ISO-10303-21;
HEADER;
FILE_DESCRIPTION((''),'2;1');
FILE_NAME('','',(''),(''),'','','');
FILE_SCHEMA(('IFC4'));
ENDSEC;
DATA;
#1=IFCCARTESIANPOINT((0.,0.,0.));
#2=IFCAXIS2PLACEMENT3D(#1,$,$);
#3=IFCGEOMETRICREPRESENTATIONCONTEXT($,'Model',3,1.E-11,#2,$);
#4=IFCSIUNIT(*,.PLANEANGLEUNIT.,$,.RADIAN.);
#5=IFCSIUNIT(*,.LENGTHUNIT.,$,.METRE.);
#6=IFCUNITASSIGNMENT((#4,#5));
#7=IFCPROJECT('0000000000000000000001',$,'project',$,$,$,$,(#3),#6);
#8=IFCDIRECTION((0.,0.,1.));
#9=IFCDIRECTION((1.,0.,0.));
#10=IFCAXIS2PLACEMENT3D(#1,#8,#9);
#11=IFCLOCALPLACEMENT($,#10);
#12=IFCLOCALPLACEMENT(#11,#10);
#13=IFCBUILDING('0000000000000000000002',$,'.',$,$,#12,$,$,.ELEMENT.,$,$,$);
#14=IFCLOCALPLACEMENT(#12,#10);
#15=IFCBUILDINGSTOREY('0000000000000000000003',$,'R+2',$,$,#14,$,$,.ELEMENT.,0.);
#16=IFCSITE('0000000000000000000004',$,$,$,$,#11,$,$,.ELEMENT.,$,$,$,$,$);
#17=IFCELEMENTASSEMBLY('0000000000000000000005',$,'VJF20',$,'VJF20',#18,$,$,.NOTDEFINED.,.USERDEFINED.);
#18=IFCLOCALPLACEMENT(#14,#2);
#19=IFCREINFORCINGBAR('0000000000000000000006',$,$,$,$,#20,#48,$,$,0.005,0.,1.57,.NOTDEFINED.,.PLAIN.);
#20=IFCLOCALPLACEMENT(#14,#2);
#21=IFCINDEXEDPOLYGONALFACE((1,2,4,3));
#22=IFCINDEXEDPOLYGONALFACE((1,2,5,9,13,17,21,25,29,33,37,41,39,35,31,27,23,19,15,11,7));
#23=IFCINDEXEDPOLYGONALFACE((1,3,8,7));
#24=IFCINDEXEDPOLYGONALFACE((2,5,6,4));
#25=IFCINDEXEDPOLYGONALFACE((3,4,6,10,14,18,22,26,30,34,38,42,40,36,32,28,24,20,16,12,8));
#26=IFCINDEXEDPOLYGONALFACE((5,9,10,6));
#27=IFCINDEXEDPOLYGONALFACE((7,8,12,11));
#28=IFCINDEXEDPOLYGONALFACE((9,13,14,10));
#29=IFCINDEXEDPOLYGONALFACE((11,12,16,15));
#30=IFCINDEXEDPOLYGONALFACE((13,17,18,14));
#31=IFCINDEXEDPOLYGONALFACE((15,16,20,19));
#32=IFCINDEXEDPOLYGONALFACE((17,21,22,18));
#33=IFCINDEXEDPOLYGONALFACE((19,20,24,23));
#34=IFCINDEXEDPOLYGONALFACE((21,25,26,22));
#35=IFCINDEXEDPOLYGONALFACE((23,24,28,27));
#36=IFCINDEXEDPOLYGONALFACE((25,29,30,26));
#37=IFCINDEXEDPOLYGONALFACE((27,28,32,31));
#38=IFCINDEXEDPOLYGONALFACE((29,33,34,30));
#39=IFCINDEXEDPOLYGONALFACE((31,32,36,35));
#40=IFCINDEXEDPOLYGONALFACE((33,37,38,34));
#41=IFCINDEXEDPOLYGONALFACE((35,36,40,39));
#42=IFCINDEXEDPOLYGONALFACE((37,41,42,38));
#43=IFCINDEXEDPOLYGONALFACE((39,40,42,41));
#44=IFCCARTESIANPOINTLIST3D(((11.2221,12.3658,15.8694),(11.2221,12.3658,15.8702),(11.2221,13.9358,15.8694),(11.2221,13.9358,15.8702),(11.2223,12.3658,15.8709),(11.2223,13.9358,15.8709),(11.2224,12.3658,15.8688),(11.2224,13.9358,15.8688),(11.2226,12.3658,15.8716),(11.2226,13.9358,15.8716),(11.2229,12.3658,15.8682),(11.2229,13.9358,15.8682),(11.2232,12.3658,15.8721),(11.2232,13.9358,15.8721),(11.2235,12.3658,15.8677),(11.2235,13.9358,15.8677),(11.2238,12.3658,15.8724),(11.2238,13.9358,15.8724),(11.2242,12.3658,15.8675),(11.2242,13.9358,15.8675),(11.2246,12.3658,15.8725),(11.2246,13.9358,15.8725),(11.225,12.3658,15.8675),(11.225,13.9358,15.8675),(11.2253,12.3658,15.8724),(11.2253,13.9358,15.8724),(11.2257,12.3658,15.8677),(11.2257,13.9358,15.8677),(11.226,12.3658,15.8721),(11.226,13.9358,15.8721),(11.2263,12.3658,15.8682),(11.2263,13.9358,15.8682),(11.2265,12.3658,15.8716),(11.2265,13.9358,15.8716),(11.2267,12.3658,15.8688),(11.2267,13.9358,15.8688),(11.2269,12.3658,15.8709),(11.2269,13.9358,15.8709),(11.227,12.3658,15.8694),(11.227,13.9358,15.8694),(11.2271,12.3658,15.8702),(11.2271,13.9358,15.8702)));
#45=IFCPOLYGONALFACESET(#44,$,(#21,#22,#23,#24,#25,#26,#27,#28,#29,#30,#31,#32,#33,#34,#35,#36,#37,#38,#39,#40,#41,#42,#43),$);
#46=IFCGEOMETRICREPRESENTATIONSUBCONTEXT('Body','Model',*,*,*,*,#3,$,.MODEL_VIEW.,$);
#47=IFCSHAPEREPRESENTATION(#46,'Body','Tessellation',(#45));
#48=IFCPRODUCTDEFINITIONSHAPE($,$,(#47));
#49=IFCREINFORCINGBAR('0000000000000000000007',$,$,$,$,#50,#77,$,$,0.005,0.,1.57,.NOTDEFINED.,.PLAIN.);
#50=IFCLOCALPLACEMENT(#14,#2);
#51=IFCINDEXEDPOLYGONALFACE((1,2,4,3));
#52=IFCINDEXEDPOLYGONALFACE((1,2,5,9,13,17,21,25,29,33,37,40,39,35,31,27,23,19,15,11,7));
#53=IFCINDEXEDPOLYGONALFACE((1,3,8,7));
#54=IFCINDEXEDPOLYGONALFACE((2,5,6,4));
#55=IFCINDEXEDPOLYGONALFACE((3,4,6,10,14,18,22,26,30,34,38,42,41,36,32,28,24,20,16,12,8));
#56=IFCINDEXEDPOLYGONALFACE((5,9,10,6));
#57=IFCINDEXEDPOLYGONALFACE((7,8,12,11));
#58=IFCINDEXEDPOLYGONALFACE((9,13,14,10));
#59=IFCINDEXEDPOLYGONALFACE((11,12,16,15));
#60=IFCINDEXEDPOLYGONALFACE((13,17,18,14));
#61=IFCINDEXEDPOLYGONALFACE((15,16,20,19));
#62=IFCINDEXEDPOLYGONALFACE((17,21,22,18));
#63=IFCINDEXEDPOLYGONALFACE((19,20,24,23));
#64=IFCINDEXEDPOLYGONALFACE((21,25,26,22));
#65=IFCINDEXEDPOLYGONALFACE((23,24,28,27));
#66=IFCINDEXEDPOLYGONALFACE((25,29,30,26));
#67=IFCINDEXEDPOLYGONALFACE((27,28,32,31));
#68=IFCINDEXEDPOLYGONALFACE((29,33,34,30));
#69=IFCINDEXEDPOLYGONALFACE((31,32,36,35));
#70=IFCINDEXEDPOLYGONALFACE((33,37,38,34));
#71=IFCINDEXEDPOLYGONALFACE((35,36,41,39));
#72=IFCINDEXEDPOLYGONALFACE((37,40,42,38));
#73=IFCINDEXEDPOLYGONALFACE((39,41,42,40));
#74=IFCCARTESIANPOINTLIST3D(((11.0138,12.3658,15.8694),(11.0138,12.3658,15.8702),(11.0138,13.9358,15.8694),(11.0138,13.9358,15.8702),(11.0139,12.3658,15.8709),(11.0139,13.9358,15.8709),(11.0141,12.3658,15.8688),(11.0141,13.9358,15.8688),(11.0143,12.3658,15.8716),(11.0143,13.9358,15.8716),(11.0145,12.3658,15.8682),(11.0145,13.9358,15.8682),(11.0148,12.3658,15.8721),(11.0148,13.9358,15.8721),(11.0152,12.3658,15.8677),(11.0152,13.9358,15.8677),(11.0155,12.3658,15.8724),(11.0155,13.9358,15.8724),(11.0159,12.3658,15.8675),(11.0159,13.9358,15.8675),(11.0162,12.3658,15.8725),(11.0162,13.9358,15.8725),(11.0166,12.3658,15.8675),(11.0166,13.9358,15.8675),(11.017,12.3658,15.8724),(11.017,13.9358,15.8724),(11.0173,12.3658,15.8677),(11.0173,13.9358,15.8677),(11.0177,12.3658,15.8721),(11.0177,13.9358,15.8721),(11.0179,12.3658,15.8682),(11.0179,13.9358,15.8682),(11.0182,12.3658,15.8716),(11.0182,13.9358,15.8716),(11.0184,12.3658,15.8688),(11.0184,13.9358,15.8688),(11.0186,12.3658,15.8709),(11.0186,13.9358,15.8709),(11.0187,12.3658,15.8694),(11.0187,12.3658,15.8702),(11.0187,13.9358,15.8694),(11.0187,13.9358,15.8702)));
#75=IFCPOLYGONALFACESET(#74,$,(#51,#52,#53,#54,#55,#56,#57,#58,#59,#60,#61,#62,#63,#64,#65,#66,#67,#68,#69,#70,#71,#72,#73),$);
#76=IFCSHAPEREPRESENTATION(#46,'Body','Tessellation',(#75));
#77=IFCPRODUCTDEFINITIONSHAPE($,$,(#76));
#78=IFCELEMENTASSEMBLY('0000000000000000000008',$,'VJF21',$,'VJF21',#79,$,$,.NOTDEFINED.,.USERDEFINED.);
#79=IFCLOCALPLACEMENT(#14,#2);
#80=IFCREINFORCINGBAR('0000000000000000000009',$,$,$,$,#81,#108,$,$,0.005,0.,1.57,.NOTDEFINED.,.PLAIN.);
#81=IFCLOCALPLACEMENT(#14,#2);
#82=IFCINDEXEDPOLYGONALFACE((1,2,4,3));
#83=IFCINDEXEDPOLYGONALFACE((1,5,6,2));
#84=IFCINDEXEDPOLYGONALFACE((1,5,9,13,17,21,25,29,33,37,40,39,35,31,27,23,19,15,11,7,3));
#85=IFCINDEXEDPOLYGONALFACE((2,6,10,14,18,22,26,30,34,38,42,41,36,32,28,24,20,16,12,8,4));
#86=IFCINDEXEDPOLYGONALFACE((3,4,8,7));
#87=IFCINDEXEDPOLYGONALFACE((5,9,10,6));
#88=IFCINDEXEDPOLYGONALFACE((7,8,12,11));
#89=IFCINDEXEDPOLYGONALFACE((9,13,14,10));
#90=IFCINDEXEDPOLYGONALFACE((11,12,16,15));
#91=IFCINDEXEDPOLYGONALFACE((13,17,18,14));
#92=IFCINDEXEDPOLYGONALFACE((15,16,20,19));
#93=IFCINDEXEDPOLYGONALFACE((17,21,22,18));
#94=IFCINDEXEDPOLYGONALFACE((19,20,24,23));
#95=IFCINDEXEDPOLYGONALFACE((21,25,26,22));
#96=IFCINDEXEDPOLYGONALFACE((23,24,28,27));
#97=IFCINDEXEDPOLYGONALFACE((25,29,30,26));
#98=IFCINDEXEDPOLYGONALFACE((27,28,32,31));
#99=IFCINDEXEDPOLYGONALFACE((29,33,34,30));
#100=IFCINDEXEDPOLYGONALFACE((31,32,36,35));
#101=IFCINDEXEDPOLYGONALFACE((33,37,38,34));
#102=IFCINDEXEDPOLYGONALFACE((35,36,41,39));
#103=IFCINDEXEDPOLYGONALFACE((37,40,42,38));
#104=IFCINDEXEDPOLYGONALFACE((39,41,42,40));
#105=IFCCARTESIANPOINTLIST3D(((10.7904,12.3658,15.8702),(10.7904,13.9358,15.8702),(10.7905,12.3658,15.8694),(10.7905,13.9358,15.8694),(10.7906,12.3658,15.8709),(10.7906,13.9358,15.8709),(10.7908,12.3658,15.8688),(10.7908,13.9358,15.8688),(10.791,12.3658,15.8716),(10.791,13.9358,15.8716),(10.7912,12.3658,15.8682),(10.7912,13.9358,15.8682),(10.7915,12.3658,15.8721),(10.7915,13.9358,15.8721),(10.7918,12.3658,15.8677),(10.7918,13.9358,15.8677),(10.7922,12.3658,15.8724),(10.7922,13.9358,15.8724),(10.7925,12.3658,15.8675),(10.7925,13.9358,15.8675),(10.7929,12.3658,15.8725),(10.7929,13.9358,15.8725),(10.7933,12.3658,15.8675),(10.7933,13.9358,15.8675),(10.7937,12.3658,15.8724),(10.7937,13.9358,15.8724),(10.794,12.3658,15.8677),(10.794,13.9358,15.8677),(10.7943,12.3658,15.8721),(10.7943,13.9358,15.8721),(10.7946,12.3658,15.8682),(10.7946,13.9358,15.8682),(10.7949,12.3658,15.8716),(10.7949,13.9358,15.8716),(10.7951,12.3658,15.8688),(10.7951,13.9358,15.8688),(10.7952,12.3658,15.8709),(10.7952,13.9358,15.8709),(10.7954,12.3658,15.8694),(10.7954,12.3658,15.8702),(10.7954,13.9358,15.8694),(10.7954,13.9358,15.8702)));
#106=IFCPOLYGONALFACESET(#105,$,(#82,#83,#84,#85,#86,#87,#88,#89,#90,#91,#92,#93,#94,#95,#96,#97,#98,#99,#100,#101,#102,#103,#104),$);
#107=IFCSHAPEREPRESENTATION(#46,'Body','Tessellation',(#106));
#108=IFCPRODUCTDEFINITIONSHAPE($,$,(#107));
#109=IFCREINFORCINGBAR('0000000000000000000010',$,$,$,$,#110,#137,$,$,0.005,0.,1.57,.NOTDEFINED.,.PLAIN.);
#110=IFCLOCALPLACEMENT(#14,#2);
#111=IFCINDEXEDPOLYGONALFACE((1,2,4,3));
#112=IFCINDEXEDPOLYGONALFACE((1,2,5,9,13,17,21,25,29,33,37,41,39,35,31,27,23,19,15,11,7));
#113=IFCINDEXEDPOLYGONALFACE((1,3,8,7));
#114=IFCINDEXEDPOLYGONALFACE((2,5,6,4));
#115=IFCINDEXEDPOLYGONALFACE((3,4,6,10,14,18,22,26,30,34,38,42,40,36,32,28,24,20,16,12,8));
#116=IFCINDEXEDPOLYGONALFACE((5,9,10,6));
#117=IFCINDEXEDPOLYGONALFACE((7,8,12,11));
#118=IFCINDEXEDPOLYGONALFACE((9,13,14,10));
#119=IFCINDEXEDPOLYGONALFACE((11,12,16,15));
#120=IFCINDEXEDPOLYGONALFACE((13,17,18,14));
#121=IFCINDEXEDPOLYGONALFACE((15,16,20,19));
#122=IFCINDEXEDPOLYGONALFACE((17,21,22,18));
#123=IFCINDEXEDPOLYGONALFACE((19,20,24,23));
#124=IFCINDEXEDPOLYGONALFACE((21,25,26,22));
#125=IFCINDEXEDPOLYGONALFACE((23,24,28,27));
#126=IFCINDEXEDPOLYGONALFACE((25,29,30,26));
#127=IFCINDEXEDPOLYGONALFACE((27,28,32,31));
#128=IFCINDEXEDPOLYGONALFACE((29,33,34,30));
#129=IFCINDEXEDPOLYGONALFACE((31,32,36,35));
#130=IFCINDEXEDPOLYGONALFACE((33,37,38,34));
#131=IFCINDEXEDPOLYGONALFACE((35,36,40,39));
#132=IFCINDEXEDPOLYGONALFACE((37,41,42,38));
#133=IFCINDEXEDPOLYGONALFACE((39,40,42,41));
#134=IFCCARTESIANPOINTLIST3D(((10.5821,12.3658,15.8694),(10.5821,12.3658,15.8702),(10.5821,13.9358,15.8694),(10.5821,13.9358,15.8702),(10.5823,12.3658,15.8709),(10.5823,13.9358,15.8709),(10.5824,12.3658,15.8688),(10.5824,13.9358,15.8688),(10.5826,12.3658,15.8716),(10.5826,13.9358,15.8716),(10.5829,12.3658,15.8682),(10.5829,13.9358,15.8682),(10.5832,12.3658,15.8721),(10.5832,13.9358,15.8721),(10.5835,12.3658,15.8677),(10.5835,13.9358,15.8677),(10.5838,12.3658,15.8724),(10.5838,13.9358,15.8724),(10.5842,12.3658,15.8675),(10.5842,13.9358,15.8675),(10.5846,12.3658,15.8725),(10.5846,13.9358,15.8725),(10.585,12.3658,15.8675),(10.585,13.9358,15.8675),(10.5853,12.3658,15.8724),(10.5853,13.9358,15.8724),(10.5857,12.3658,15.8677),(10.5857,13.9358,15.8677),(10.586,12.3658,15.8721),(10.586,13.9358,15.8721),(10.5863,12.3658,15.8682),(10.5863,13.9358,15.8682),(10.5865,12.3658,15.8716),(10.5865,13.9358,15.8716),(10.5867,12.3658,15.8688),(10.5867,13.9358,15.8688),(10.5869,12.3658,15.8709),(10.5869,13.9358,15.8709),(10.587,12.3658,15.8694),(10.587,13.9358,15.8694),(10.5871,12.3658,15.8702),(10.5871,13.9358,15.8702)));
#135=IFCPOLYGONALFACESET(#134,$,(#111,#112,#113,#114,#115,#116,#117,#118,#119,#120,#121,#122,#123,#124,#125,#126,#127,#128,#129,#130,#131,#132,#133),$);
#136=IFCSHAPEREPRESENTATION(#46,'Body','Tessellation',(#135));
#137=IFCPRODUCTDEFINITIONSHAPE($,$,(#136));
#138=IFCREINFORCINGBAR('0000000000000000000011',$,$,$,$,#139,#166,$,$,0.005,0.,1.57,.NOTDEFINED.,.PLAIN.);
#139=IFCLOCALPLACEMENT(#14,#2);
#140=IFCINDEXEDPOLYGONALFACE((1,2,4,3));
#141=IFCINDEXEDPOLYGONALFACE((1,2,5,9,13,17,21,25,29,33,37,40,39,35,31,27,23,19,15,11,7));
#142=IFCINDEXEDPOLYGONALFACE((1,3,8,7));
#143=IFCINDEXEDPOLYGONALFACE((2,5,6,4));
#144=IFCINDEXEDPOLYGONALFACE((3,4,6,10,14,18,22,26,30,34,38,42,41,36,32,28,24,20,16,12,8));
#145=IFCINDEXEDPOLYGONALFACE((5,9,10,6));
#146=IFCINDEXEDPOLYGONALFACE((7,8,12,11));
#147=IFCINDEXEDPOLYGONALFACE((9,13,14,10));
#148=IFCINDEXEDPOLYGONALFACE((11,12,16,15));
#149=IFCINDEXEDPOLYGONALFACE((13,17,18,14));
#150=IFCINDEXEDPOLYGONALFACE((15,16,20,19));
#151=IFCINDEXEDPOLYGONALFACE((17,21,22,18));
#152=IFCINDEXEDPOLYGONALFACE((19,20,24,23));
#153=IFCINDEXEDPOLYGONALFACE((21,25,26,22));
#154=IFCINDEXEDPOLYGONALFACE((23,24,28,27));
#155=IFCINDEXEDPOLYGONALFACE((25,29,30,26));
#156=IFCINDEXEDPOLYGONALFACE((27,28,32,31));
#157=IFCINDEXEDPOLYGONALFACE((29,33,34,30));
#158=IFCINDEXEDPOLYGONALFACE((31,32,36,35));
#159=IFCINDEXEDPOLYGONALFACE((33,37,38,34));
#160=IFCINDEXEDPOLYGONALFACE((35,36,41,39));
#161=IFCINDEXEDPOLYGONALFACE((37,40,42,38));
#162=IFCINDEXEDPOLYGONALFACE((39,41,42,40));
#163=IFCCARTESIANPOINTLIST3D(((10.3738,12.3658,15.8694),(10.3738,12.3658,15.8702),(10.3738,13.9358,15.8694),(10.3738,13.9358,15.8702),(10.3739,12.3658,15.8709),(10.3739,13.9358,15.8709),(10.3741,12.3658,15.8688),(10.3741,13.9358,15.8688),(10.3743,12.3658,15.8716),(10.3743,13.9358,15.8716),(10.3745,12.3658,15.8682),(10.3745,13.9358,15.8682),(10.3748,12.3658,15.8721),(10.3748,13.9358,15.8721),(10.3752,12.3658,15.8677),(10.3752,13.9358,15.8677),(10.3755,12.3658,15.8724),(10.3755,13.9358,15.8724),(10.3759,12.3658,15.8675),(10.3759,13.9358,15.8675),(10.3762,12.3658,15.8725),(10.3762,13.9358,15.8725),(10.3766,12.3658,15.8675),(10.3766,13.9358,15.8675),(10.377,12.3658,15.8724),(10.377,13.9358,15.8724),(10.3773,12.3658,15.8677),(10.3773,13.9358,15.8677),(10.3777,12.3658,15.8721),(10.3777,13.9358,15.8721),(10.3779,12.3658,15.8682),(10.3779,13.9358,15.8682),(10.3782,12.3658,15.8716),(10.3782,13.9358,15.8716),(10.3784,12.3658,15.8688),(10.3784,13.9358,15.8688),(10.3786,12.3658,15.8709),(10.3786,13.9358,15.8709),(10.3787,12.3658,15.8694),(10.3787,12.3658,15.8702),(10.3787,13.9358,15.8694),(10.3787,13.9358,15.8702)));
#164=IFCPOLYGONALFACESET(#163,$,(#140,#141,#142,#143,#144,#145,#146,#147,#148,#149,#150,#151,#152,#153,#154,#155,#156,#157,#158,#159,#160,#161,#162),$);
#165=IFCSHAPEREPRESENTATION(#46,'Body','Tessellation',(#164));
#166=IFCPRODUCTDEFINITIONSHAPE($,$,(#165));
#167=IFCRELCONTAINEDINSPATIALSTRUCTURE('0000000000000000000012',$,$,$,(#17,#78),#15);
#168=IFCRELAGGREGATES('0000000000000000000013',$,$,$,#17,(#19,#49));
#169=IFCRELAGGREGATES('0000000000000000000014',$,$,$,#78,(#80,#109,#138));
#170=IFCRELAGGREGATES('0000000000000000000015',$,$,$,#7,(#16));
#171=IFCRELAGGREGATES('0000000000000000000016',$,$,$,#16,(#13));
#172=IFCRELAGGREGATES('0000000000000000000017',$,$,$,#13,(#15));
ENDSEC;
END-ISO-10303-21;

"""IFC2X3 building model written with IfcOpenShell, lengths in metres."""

from ifc_helpers import new_model, entity, si_unit, origin, origin_with_axes, place, context, subcontext, project, spatial, shape, element, aggregate, save


model = new_model("IFC2X3")

# Units and contexts
model_context = context("Model", 3, precision=1e-11, world=origin())
body_context = subcontext(model_context, "Body", "Model", "MODEL_VIEW")
ifc_project = project(units=[si_unit("PLANEANGLEUNIT", "RADIAN"), si_unit("LENGTHUNIT", "METRE")], contexts=[model_context])

# Site, building, storey
site_placement = place(None, origin_with_axes())
site = spatial("IfcSite", under=ifc_project, at=site_placement, CompositionType="ELEMENT")
building_placement = place(site_placement, origin_with_axes())
building = spatial("IfcBuilding", under=site, at=building_placement, Name=".", CompositionType="ELEMENT")
storey_placement = place(building_placement, origin_with_axes())
storey = spatial("IfcBuildingStorey", under=building, at=storey_placement, Name="R+2", CompositionType="ELEMENT", Elevation=0.0)

# Element assemblies, reinforcing bars
assembly_1_placement = place(storey_placement, origin_with_axes())
assembly_1 = element("IfcElementAssembly", 1, at=assembly_1_placement, inside=storey, Name="VJF20", ObjectType="VJF20", AssemblyPlace="NOTDEFINED", PredefinedType="USERDEFINED")
reinforcing_bar_1_placement = place(assembly_1_placement, origin_with_axes())
reinforcing_bar_1 = element("IfcReinforcingBar", 2, at=reinforcing_bar_1_placement, BarLength=1.57, BarRole="NOTDEFINED", BarSurface="PLAIN", CrossSectionArea=0.0, NominalDiameter=0.005, shapes=[
    shape(body_context, "Body", "AdvancedSweptSolid", [entity("IfcSweptDiskSolid", entity("IfcPolyline", [entity("IfcCartesianPoint", [11.2246, 12.3658, 15.87]), entity("IfcCartesianPoint", [11.2246, 13.9358, 15.87])]), 0.0025, None, 0.0, 1.57)]),
    shape(body_context, "Body", "AdvancedSweptSolid", [entity("IfcSweptDiskSolid", entity("IfcPolyline", [entity("IfcCartesianPoint", [11.2246, 12.3658, 15.87]), entity("IfcCartesianPoint", [11.2246, 13.9358, 15.87])]), 0.0025, None, 0.0, 1.57)]),
])
reinforcing_bar_2_placement = place(assembly_1_placement, origin_with_axes())
reinforcing_bar_2 = element("IfcReinforcingBar", 3, at=reinforcing_bar_2_placement, BarLength=1.57, BarRole="NOTDEFINED", BarSurface="PLAIN", CrossSectionArea=0.0, NominalDiameter=0.005, shapes=[
    shape(body_context, "Body", "AdvancedSweptSolid", [entity("IfcSweptDiskSolid", entity("IfcPolyline", [entity("IfcCartesianPoint", [11.0162, 12.3658, 15.87]), entity("IfcCartesianPoint", [11.0162, 13.9358, 15.87])]), 0.0025, None, 0.0, 1.57)]),
    shape(body_context, "Body", "AdvancedSweptSolid", [entity("IfcSweptDiskSolid", entity("IfcPolyline", [entity("IfcCartesianPoint", [11.0162, 12.3658, 15.87]), entity("IfcCartesianPoint", [11.0162, 13.9358, 15.87])]), 0.0025, None, 0.0, 1.57)]),
])
aggregate(assembly_1, [reinforcing_bar_1, reinforcing_bar_2])
assembly_2_placement = place(storey_placement, origin_with_axes())
assembly_2 = element("IfcElementAssembly", 4, at=assembly_2_placement, inside=storey, Name="VJF21", ObjectType="VJF21", AssemblyPlace="NOTDEFINED", PredefinedType="USERDEFINED")
reinforcing_bar_3_placement = place(assembly_2_placement, origin_with_axes())
reinforcing_bar_3 = element("IfcReinforcingBar", 5, at=reinforcing_bar_3_placement, BarLength=1.57, BarRole="NOTDEFINED", BarSurface="PLAIN", CrossSectionArea=0.0, NominalDiameter=0.005, shapes=[
    shape(body_context, "Body", "AdvancedSweptSolid", [entity("IfcSweptDiskSolid", entity("IfcPolyline", [entity("IfcCartesianPoint", [10.7929, 12.3658, 15.87]), entity("IfcCartesianPoint", [10.7929, 13.9358, 15.87])]), 0.0025, None, 0.0, 1.57)]),
    shape(body_context, "Body", "AdvancedSweptSolid", [entity("IfcSweptDiskSolid", entity("IfcPolyline", [entity("IfcCartesianPoint", [10.7929, 12.3658, 15.87]), entity("IfcCartesianPoint", [10.7929, 13.9358, 15.87])]), 0.0025, None, 0.0, 1.57)]),
])
reinforcing_bar_4_placement = place(assembly_2_placement, origin_with_axes())
reinforcing_bar_4 = element("IfcReinforcingBar", 6, at=reinforcing_bar_4_placement, BarLength=1.57, BarRole="NOTDEFINED", BarSurface="PLAIN", CrossSectionArea=0.0, NominalDiameter=0.005, shapes=[
    shape(body_context, "Body", "AdvancedSweptSolid", [entity("IfcSweptDiskSolid", entity("IfcPolyline", [entity("IfcCartesianPoint", [10.5846, 12.3658, 15.87]), entity("IfcCartesianPoint", [10.5846, 13.9358, 15.87])]), 0.0025, None, 0.0, 1.57)]),
    shape(body_context, "Body", "AdvancedSweptSolid", [entity("IfcSweptDiskSolid", entity("IfcPolyline", [entity("IfcCartesianPoint", [10.5846, 12.3658, 15.87]), entity("IfcCartesianPoint", [10.5846, 13.9358, 15.87])]), 0.0025, None, 0.0, 1.57)]),
])
reinforcing_bar_5_placement = place(assembly_2_placement, origin_with_axes())
reinforcing_bar_5 = element("IfcReinforcingBar", 7, at=reinforcing_bar_5_placement, BarLength=1.57, BarRole="NOTDEFINED", BarSurface="PLAIN", CrossSectionArea=0.0, NominalDiameter=0.005, shapes=[
    shape(body_context, "Body", "AdvancedSweptSolid", [entity("IfcSweptDiskSolid", entity("IfcPolyline", [entity("IfcCartesianPoint", [10.3762, 12.3658, 15.87]), entity("IfcCartesianPoint", [10.3762, 13.9358, 15.87])]), 0.0025, None, 0.0, 1.57)]),
    shape(body_context, "Body", "AdvancedSweptSolid", [entity("IfcSweptDiskSolid", entity("IfcPolyline", [entity("IfcCartesianPoint", [10.3762, 12.3658, 15.87]), entity("IfcCartesianPoint", [10.3762, 13.9358, 15.87])]), 0.0025, None, 0.0, 1.57)]),
])
aggregate(assembly_2, [reinforcing_bar_3, reinforcing_bar_4, reinforcing_bar_5])

save(model, "model.ifc")
